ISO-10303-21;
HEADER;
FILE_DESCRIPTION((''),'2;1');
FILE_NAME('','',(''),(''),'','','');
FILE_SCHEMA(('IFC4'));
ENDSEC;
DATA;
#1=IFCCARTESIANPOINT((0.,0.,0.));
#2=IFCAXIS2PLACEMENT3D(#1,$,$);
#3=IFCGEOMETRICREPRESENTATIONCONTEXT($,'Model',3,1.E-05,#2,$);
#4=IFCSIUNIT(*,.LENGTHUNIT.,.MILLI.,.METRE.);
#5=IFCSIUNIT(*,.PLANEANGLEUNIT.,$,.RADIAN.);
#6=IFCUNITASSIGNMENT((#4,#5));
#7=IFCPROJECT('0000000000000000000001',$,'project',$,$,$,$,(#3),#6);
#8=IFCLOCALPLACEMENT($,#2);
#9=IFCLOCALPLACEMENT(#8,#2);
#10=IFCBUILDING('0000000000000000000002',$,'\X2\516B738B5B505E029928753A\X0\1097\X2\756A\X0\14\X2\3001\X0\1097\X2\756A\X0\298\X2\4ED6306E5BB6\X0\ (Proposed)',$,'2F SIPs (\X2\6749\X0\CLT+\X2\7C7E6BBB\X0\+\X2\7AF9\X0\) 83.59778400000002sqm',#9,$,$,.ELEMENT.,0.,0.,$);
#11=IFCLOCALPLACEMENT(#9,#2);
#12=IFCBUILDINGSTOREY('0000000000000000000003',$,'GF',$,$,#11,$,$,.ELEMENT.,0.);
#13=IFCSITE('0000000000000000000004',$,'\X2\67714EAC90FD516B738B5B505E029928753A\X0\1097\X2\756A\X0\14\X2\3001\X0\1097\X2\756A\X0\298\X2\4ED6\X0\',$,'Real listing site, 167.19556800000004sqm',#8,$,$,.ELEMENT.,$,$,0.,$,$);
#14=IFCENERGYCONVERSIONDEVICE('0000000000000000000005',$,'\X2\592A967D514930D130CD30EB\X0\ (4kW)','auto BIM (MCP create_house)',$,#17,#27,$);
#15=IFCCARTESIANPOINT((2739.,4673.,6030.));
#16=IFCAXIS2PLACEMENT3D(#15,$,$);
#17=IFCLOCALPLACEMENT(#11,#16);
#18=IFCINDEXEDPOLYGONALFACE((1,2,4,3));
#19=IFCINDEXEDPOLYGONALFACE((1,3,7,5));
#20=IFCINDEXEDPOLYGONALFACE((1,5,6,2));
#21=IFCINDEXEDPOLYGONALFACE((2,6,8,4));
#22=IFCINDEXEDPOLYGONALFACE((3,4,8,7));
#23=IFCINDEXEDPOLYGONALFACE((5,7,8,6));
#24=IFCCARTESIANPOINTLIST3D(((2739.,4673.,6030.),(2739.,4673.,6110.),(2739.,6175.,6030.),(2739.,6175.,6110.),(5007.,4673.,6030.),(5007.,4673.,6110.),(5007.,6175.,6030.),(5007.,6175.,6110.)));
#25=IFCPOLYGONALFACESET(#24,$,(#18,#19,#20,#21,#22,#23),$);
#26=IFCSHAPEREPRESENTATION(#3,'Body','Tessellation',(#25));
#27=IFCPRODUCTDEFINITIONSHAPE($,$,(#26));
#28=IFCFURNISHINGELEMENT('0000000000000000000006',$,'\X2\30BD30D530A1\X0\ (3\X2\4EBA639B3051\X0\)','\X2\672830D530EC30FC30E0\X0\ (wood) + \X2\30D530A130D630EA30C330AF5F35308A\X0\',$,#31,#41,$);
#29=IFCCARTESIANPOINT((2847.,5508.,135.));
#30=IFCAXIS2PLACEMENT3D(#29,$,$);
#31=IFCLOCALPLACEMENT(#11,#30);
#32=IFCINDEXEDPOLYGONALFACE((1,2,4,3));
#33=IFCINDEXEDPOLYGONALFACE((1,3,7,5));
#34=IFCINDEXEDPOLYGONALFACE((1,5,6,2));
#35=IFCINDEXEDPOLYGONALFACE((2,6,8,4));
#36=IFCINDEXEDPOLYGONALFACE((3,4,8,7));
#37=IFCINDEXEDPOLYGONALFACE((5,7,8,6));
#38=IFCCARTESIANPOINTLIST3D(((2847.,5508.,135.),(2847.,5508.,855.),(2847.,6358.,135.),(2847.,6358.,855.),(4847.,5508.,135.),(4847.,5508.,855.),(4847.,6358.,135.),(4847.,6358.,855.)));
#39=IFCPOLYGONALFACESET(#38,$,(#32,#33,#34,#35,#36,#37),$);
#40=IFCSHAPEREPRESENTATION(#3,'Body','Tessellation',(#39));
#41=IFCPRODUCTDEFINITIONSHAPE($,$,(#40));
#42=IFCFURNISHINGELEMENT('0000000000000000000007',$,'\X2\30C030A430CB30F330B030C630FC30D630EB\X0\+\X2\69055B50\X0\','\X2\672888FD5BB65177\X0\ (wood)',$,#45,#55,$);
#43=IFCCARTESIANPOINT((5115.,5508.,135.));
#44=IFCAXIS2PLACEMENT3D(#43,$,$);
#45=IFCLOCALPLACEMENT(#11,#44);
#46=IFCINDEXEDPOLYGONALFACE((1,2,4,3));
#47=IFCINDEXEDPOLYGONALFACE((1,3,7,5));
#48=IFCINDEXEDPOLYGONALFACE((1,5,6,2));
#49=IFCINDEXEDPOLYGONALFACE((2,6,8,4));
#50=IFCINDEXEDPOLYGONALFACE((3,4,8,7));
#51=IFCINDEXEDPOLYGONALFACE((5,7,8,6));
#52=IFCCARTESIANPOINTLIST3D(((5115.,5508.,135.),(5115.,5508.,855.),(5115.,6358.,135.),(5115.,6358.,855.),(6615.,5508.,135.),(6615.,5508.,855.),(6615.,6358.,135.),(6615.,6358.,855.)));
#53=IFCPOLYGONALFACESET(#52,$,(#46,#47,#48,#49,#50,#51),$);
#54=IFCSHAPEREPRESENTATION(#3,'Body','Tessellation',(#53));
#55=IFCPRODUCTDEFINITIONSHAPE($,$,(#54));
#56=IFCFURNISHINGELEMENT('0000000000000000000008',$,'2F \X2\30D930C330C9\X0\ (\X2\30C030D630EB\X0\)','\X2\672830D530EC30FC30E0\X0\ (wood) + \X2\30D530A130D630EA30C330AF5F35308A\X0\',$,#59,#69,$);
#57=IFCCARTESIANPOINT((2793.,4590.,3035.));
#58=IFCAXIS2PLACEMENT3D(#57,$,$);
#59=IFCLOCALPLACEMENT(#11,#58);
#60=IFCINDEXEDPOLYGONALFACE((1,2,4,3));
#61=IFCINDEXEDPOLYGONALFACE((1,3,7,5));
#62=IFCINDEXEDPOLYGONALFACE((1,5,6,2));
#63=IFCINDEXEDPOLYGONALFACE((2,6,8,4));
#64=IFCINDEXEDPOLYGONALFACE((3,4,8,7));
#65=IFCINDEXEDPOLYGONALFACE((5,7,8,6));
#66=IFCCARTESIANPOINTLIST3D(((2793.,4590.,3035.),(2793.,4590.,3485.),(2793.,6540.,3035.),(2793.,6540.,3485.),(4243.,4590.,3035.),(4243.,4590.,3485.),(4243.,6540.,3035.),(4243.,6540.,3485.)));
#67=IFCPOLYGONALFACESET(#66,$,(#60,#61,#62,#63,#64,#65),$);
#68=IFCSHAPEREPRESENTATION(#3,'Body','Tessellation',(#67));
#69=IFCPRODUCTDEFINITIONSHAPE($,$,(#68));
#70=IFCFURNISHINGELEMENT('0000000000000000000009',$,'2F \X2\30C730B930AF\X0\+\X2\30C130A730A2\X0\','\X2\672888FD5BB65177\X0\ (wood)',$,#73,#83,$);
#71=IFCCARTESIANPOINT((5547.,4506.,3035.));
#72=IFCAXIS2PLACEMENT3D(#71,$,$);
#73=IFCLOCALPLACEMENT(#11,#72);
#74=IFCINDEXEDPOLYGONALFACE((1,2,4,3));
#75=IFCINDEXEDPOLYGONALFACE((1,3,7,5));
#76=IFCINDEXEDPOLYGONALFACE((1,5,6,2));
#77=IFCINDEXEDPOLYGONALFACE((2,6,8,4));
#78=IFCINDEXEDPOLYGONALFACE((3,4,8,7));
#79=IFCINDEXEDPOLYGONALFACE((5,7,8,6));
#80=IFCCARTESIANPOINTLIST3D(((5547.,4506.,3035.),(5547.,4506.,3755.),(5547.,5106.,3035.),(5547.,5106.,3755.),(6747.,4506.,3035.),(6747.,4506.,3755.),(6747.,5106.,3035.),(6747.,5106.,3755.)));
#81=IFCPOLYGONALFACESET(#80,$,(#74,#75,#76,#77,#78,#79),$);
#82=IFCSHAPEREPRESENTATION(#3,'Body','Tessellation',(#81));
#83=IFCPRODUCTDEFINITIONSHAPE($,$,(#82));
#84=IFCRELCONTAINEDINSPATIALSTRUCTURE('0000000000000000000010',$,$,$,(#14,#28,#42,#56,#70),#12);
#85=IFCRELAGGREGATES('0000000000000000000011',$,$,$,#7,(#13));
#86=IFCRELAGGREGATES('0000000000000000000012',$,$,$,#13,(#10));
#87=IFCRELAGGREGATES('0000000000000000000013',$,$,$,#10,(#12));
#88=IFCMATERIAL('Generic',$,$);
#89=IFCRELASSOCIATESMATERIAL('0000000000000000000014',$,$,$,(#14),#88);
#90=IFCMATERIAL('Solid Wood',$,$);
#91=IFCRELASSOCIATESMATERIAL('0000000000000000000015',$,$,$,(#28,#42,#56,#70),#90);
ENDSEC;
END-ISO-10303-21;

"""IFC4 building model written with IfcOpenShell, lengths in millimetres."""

from ifc_helpers import new_model, si_unit, frame, frame_2d, origin, place, context, project, spatial, rectangle, extrude, material, element, save


model = new_model("IFC4")

# Units and contexts
model_context = context("Model", 3, precision=1e-05, world=origin())
ifc_project = project(units=[si_unit("LENGTHUNIT", "METRE", prefix="MILLI"), si_unit("PLANEANGLEUNIT", "RADIAN")], contexts=[model_context])

# Site, building, storey
site_placement = place(None, origin())
site = spatial("IfcSite", under=ifc_project, at=site_placement, Name="東京都八王子市館町1097番14、1097番298他", ObjectType="Real listing site, 167.19556800000004sqm", CompositionType="ELEMENT", RefElevation=0.0)
building_placement = place(site_placement, origin())
building = spatial("IfcBuilding", under=site, at=building_placement, Name="八王子市館町1097番14、1097番298他の家 (Proposed)", ObjectType="2F SIPs (杉CLT+籾殻+竹) 83.59778400000002sqm", CompositionType="ELEMENT", ElevationOfRefHeight=0.0, ElevationOfTerrain=0.0)
storey_placement = place(building_placement, origin())
storey = spatial("IfcBuildingStorey", under=building, at=storey_placement, Name="GF", CompositionType="ELEMENT", Elevation=0.0)

# Shared definitions
ifc_material_1 = material(Name="Solid Wood")

# Shared definitions
ifc_material_2 = material(Name="Generic")

# Energy conversion device
energy_conversion_device_placement = place(storey_placement, frame((2739.0, 4673.0, 6030.0)))
element("IfcEnergyConversionDevice", 1, at=energy_conversion_device_placement, inside=storey, material=ifc_material_2, Name="太陽光パネル (4kW)", Description="auto BIM (MCP create_house)", context=model_context, shape_type="SweptSolid", body=[
    extrude(rectangle(XDim=2268.0, YDim=1502.0, at=frame_2d((1134.0, 751.0))), frame((2739.0, 4673.0, 6030.0)), (0.0, 0.0, 1.0), 80.0),
])

# Furnishing elements
furnishing_1_placement = place(storey_placement, frame((2847.0, 5508.0, 135.0)))
element("IfcFurnishingElement", 2, at=furnishing_1_placement, inside=storey, material=ifc_material_1, Name="ソファ (3人掛け)", Description="木フレーム (wood) + ファブリック張り", context=model_context, shape_type="SweptSolid", body=[
    extrude(rectangle(XDim=2000.0, YDim=850.0, at=frame_2d((1000.0, 425.0))), frame((2847.0, 5508.0, 135.0)), (0.0, 0.0, 1.0), 720.0),
])
furnishing_2_placement = place(storey_placement, frame((5115.0, 5508.0, 135.0)))
element("IfcFurnishingElement", 3, at=furnishing_2_placement, inside=storey, material=ifc_material_1, Name="ダイニングテーブル+椅子", Description="木製家具 (wood)", context=model_context, shape_type="SweptSolid", body=[
    extrude(rectangle(XDim=1500.0, YDim=850.0, at=frame_2d((750.0, 425.0))), frame((5115.0, 5508.0, 135.0)), (0.0, 0.0, 1.0), 720.0),
])
furnishing_3_placement = place(storey_placement, frame((2793.0, 4590.0, 3035.0)))
element("IfcFurnishingElement", 4, at=furnishing_3_placement, inside=storey, material=ifc_material_1, Name="2F ベッド (ダブル)", Description="木フレーム (wood) + ファブリック張り", context=model_context, shape_type="SweptSolid", body=[
    extrude(rectangle(XDim=1450.0, YDim=1950.0, at=frame_2d((725.0, 975.0))), frame((2793.0, 4590.0, 3035.0)), (0.0, 0.0, 1.0), 450.0),
])
furnishing_4_placement = place(storey_placement, frame((5547.0, 4506.0, 3035.0)))
element("IfcFurnishingElement", 5, at=furnishing_4_placement, inside=storey, material=ifc_material_1, Name="2F デスク+チェア", Description="木製家具 (wood)", context=model_context, shape_type="SweptSolid", body=[
    extrude(rectangle(XDim=1200.0, YDim=600.0, at=frame_2d((600.0, 300.0))), frame((5547.0, 4506.0, 3035.0)), (0.0, 0.0, 1.0), 720.0),
])

save(model, "model.ifc")
